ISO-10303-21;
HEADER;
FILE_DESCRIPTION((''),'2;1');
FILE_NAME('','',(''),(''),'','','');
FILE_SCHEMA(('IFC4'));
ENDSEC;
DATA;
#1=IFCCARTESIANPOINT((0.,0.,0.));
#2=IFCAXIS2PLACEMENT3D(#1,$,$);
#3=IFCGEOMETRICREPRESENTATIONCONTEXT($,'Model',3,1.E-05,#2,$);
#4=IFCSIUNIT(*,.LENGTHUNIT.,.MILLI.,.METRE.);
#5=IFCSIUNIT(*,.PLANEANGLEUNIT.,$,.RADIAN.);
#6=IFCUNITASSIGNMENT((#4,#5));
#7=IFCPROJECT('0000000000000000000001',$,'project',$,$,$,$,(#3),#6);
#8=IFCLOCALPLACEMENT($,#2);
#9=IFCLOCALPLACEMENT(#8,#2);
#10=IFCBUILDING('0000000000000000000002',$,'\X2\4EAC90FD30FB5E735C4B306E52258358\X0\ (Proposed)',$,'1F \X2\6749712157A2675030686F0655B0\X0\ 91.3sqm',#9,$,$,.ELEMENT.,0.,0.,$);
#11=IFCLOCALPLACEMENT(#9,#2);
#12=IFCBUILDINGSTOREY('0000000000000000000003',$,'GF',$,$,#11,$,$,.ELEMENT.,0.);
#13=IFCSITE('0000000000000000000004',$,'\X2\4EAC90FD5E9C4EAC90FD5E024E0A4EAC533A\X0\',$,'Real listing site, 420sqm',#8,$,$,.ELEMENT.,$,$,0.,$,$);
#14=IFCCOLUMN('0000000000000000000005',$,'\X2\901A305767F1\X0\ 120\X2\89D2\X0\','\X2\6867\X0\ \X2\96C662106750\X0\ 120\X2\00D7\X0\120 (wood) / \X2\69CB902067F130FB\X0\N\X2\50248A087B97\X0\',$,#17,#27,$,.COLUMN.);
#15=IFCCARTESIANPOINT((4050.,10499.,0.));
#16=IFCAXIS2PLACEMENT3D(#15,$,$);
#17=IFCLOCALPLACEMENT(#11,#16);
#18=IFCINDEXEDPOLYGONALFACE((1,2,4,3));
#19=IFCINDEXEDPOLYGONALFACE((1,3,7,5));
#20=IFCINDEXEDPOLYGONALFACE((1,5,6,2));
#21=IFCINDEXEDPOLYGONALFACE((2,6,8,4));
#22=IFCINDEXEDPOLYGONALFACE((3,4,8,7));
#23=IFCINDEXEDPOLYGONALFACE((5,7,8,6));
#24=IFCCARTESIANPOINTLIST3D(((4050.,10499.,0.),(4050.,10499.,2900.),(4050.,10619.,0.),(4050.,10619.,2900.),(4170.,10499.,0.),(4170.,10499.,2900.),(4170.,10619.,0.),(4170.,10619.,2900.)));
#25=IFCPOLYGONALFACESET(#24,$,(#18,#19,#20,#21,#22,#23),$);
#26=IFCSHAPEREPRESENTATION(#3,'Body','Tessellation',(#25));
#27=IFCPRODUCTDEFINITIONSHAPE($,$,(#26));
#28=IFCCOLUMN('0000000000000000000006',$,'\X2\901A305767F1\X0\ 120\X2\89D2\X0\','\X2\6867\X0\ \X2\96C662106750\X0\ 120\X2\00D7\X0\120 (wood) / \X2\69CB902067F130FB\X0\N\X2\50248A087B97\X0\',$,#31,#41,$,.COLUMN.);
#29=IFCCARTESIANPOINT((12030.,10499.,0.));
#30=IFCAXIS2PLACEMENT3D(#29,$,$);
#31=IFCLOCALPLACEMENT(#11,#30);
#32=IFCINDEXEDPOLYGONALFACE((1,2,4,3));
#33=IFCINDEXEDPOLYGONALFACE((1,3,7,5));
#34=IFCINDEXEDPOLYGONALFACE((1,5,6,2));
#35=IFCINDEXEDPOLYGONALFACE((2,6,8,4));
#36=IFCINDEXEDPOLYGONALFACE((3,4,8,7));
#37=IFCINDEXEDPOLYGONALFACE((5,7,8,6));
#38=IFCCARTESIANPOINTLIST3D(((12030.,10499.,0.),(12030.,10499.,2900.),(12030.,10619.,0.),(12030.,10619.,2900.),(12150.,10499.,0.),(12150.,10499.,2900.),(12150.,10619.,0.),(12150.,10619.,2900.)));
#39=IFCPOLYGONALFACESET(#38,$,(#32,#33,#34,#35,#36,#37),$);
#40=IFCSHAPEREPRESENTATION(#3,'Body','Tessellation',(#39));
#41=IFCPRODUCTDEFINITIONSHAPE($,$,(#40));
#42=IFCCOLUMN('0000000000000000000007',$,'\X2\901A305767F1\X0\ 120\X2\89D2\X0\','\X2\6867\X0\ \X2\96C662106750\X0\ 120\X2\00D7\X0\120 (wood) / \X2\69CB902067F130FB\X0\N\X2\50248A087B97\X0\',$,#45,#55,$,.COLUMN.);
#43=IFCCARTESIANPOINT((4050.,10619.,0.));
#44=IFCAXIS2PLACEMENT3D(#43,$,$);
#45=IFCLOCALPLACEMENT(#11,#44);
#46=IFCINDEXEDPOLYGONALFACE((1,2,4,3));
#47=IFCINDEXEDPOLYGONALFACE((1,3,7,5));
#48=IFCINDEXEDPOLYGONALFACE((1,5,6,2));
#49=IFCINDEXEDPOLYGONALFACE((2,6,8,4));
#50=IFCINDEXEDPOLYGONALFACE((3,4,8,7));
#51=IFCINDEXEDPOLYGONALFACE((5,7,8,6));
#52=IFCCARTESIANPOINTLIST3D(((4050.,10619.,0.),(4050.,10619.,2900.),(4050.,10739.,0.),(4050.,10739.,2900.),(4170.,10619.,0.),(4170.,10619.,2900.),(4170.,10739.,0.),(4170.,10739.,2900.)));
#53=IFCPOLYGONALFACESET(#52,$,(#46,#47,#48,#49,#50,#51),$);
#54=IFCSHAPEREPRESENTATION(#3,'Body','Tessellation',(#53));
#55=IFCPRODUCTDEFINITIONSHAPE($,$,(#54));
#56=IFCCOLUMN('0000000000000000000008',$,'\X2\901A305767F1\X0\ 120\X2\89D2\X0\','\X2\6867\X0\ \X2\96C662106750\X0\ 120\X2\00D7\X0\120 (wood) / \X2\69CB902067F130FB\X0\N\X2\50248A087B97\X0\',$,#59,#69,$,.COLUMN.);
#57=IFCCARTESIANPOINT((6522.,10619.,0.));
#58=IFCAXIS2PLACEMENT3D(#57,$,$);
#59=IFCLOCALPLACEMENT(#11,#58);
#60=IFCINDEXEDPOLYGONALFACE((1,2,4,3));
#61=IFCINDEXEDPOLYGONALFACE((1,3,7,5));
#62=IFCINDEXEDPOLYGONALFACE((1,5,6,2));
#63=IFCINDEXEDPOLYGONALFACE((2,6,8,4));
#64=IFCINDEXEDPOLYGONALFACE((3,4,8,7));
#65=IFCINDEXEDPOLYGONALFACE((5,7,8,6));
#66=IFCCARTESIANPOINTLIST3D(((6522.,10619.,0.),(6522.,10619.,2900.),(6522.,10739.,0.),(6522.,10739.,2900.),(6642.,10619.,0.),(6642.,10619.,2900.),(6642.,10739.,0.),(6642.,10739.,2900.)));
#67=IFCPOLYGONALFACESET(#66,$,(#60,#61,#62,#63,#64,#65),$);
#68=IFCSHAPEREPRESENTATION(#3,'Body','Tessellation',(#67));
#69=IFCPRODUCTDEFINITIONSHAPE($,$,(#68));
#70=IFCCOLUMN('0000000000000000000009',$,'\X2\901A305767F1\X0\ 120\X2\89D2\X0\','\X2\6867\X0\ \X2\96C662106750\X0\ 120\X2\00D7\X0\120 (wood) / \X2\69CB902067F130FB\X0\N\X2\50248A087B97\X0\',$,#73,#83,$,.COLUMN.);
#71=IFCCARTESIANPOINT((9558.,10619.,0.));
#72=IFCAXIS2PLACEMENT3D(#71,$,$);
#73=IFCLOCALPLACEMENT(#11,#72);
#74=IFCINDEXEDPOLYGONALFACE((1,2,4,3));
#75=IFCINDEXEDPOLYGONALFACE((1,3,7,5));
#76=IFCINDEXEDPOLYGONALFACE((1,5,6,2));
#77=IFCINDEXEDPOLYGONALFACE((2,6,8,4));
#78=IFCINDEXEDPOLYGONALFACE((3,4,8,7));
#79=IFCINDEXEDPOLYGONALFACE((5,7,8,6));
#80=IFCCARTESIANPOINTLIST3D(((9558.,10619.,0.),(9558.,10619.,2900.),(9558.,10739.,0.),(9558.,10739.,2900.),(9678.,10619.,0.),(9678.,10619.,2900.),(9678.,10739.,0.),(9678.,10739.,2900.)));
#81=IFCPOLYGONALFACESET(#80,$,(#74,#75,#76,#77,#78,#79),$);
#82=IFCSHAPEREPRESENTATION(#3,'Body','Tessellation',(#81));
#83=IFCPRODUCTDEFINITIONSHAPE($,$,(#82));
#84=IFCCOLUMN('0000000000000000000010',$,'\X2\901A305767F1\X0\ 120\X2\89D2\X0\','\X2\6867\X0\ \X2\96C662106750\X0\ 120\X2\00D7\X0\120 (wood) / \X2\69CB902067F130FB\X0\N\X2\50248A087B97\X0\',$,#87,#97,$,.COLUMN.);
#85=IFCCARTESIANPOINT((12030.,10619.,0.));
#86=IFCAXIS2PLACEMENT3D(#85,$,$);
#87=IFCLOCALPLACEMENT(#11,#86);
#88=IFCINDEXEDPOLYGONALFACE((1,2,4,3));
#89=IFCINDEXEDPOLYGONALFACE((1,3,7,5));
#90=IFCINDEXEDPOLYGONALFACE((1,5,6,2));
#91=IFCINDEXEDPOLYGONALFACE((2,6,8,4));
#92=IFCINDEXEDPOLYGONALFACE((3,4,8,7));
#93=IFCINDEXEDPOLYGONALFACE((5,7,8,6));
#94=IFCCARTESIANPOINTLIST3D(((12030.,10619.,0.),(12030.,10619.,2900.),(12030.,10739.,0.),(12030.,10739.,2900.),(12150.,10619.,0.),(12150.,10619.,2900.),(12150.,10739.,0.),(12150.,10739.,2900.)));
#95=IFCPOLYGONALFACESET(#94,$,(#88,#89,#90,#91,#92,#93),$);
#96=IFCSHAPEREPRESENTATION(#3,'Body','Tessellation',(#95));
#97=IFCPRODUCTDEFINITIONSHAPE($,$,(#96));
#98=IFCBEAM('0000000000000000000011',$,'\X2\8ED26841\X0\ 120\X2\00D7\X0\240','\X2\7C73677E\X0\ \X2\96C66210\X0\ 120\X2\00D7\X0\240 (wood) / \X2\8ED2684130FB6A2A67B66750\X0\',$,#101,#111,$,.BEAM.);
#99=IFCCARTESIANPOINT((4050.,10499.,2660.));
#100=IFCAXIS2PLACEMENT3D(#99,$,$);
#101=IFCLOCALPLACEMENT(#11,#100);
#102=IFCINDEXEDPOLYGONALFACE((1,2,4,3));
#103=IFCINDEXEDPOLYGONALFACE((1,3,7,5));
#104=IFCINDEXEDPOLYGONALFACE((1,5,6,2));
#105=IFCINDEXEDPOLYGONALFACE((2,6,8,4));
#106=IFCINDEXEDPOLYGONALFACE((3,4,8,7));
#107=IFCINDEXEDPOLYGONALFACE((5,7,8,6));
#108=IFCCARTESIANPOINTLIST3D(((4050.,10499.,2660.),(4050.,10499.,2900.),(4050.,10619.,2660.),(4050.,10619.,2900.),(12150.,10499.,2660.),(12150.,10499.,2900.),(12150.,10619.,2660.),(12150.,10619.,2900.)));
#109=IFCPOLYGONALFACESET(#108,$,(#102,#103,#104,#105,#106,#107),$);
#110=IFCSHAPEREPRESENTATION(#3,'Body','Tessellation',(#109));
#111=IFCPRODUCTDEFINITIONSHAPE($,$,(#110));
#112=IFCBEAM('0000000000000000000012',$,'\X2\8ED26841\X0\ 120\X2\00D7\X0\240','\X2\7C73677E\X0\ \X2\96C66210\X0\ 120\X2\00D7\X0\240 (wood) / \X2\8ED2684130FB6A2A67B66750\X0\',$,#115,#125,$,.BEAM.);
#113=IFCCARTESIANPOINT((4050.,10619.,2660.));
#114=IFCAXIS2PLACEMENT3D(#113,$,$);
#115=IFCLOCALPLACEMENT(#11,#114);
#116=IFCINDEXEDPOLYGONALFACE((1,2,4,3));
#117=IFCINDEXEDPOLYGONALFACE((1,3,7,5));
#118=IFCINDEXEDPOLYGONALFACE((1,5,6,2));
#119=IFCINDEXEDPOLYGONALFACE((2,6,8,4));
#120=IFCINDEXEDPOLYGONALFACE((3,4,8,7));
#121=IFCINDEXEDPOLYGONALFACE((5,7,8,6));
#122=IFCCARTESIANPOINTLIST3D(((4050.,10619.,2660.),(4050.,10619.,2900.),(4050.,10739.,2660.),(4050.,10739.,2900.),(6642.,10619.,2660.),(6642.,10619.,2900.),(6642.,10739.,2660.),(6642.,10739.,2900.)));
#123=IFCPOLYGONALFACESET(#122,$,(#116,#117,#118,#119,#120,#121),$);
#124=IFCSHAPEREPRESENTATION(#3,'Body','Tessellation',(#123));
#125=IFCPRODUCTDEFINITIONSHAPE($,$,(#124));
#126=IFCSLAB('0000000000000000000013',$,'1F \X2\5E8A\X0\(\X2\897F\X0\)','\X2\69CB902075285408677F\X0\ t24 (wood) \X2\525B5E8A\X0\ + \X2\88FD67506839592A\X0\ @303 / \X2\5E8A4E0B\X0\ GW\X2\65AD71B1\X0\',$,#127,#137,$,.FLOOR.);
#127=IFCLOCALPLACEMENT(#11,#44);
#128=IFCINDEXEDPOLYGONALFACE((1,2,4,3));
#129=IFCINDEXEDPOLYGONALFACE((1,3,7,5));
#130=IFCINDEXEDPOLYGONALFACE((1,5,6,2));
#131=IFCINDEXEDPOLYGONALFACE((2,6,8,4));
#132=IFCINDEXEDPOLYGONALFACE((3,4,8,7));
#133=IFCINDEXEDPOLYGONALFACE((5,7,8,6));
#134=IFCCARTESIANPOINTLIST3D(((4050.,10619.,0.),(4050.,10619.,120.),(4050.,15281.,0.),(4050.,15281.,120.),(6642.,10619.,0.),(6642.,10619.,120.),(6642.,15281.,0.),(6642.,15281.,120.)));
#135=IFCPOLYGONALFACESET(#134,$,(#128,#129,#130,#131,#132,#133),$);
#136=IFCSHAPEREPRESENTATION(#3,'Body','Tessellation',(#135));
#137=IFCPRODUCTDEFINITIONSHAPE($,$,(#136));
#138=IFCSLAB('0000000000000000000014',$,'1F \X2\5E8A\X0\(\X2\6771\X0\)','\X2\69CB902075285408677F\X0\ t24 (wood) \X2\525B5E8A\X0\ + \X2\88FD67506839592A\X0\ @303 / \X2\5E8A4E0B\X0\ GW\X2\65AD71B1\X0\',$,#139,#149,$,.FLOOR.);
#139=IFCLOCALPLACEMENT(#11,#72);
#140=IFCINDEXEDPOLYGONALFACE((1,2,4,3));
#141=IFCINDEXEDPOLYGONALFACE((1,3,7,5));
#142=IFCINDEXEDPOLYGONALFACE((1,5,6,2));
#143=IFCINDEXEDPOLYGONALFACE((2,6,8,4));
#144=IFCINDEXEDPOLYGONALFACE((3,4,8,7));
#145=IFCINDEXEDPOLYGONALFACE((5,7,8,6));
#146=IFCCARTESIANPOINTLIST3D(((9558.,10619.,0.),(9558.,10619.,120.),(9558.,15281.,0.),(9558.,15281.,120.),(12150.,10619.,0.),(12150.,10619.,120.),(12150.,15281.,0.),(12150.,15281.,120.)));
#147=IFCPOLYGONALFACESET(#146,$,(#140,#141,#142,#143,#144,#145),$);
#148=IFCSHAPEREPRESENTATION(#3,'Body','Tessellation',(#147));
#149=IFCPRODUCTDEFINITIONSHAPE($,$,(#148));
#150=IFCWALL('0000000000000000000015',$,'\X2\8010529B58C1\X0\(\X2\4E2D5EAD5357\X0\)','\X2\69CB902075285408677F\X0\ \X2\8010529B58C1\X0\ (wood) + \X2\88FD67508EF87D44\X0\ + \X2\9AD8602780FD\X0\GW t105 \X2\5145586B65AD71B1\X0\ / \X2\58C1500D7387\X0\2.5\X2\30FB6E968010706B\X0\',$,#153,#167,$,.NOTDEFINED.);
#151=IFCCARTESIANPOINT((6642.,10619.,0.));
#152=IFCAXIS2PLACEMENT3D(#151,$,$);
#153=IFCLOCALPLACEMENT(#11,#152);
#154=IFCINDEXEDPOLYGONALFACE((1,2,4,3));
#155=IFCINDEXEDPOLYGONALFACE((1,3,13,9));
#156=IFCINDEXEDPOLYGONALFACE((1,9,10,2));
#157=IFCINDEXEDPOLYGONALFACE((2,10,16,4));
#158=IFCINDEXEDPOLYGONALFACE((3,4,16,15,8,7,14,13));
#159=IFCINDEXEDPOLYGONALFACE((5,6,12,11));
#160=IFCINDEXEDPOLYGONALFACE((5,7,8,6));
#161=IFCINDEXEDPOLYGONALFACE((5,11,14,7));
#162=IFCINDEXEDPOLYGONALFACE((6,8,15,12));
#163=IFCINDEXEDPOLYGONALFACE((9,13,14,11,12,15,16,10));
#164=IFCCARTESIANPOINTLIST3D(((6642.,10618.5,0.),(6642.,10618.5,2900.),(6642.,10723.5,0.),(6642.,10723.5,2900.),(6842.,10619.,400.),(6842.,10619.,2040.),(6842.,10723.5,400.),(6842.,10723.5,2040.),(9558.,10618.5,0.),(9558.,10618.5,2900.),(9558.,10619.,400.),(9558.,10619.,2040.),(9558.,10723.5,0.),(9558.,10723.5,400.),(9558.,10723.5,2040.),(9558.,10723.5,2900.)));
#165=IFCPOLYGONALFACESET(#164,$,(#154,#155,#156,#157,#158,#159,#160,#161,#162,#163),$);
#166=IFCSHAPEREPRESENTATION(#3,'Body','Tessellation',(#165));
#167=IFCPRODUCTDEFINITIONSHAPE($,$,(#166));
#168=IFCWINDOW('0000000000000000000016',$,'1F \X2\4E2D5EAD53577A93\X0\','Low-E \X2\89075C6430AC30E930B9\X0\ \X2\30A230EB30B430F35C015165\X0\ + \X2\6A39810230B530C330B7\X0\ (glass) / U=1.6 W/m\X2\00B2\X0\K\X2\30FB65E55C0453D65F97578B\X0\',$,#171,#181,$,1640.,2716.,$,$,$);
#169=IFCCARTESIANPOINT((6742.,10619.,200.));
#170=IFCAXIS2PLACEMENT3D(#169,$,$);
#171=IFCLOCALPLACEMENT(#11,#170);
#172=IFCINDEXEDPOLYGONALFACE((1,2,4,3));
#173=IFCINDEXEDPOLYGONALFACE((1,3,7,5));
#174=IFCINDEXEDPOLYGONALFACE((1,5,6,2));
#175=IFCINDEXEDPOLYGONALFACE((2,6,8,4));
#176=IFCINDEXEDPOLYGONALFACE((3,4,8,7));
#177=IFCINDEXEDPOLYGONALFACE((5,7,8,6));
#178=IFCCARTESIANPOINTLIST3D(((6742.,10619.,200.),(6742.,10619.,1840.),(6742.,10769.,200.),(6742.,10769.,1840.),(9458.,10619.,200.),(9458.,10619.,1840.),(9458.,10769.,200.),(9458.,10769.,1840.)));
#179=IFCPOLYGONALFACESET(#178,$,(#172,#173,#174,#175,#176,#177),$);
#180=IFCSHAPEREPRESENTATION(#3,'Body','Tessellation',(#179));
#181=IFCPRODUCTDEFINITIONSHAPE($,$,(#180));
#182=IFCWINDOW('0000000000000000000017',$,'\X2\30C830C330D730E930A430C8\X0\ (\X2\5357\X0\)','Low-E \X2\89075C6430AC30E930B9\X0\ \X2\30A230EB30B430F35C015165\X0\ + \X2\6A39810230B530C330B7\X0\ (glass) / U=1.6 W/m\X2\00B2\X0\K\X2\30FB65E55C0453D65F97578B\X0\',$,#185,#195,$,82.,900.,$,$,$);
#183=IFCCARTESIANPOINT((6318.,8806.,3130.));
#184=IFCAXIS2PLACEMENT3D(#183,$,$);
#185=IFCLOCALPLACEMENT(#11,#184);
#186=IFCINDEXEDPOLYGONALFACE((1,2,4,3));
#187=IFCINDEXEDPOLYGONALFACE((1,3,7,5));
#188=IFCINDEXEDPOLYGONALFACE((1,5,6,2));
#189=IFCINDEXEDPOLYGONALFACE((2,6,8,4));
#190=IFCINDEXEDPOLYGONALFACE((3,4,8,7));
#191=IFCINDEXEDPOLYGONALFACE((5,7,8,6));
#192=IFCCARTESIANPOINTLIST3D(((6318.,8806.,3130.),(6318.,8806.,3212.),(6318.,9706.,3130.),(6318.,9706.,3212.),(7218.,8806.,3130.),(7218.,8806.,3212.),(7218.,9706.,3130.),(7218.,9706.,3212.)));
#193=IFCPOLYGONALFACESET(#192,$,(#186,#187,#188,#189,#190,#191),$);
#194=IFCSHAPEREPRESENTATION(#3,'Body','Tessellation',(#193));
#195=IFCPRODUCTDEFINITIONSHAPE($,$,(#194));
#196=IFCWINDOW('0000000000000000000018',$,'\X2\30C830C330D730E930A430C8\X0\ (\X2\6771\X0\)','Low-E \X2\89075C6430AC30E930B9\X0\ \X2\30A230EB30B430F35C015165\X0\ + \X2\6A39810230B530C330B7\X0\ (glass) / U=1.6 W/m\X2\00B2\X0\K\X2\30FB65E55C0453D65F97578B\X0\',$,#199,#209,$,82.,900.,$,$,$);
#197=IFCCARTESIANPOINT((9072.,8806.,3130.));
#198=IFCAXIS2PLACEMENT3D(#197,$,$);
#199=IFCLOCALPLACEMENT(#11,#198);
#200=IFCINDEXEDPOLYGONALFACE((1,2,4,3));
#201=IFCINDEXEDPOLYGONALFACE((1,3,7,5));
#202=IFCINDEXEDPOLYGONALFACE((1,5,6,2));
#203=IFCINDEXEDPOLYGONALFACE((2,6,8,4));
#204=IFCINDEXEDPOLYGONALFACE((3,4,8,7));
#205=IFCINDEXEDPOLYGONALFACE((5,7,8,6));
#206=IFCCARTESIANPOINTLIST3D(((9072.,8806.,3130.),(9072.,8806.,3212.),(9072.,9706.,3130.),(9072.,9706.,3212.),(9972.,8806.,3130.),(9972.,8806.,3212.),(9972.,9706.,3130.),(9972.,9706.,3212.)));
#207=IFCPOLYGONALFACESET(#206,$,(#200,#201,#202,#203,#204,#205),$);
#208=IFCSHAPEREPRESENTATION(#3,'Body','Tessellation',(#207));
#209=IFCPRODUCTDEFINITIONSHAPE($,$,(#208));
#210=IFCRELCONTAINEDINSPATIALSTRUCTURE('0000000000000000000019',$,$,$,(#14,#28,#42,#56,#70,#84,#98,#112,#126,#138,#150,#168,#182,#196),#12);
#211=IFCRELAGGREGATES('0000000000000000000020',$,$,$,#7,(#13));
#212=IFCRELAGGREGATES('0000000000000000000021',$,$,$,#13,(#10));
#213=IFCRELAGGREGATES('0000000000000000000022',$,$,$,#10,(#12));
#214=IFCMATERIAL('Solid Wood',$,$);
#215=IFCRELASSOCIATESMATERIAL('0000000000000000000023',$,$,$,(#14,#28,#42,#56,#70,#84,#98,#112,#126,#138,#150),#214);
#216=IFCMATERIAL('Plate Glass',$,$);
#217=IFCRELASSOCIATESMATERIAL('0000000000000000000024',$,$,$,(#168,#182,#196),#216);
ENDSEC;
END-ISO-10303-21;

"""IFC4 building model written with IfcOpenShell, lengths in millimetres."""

from ifc_helpers import new_model, si_unit, frame, frame_2d, origin, place, context, project, spatial, rectangle, extrude, material, element, fill, save


model = new_model("IFC4")

# Units and contexts
model_context = context("Model", 3, precision=1e-05, world=origin())
ifc_project = project(units=[si_unit("LENGTHUNIT", "METRE", prefix="MILLI"), si_unit("PLANEANGLEUNIT", "RADIAN")], contexts=[model_context])

# Site, building, storey
site_placement = place(None, origin())
site = spatial("IfcSite", under=ifc_project, at=site_placement, Name="京都府京都市上京区", ObjectType="Real listing site, 420sqm", CompositionType="ELEMENT", RefElevation=0.0)
building_placement = place(site_placement, origin())
building = spatial("IfcBuilding", under=site, at=building_placement, Name="京都・平屋の別荘 (Proposed)", ObjectType="1F 杉無垢材と漆喰 91.3sqm", CompositionType="ELEMENT", ElevationOfRefHeight=0.0, ElevationOfTerrain=0.0)
storey_placement = place(building_placement, origin())
storey = spatial("IfcBuildingStorey", under=building, at=storey_placement, Name="GF", CompositionType="ELEMENT", Elevation=0.0)

# Columns
ifc_material_1 = material(Name="Solid Wood")
column_1_placement = place(storey_placement, frame((4050.0, 10499.0, 0.0)))
element("IfcColumn", 1, at=column_1_placement, inside=storey, material=ifc_material_1, Name="通し柱 120角", Description="桧 集成材 120×120 (wood) / 構造柱・N値計算", PredefinedType="COLUMN", context=model_context, shape_type="SweptSolid", body=[
    extrude(rectangle(XDim=120.0, YDim=120.0, at=frame_2d((60.0, 60.0))), frame((4050.0, 10499.0, 0.0)), (0.0, 0.0, 1.0), 2900.0),
])
column_2_placement = place(storey_placement, frame((12030.0, 10499.0, 0.0)))
element("IfcColumn", 2, at=column_2_placement, inside=storey, material=ifc_material_1, Name="通し柱 120角", Description="桧 集成材 120×120 (wood) / 構造柱・N値計算", PredefinedType="COLUMN", context=model_context, shape_type="SweptSolid", body=[
    extrude(rectangle(XDim=120.0, YDim=120.0, at=frame_2d((60.0, 60.0))), frame((12030.0, 10499.0, 0.0)), (0.0, 0.0, 1.0), 2900.0),
])
column_3_placement = place(storey_placement, frame((4050.0, 10619.0, 0.0)))
element("IfcColumn", 3, at=column_3_placement, inside=storey, material=ifc_material_1, Name="通し柱 120角", Description="桧 集成材 120×120 (wood) / 構造柱・N値計算", PredefinedType="COLUMN", context=model_context, shape_type="SweptSolid", body=[
    extrude(rectangle(XDim=120.0, YDim=120.0, at=frame_2d((60.0, 60.0))), frame((4050.0, 10619.0, 0.0)), (0.0, 0.0, 1.0), 2900.0),
])
column_4_placement = place(storey_placement, frame((6522.0, 10619.0, 0.0)))
element("IfcColumn", 4, at=column_4_placement, inside=storey, material=ifc_material_1, Name="通し柱 120角", Description="桧 集成材 120×120 (wood) / 構造柱・N値計算", PredefinedType="COLUMN", context=model_context, shape_type="SweptSolid", body=[
    extrude(rectangle(XDim=120.0, YDim=120.0, at=frame_2d((60.0, 60.0))), frame((6522.0, 10619.0, 0.0)), (0.0, 0.0, 1.0), 2900.0),
])
column_5_placement = place(storey_placement, frame((9558.0, 10619.0, 0.0)))
element("IfcColumn", 5, at=column_5_placement, inside=storey, material=ifc_material_1, Name="通し柱 120角", Description="桧 集成材 120×120 (wood) / 構造柱・N値計算", PredefinedType="COLUMN", context=model_context, shape_type="SweptSolid", body=[
    extrude(rectangle(XDim=120.0, YDim=120.0, at=frame_2d((60.0, 60.0))), frame((9558.0, 10619.0, 0.0)), (0.0, 0.0, 1.0), 2900.0),
])
column_6_placement = place(storey_placement, frame((12030.0, 10619.0, 0.0)))
element("IfcColumn", 6, at=column_6_placement, inside=storey, material=ifc_material_1, Name="通し柱 120角", Description="桧 集成材 120×120 (wood) / 構造柱・N値計算", PredefinedType="COLUMN", context=model_context, shape_type="SweptSolid", body=[
    extrude(rectangle(XDim=120.0, YDim=120.0, at=frame_2d((60.0, 60.0))), frame((12030.0, 10619.0, 0.0)), (0.0, 0.0, 1.0), 2900.0),
])

# Beams
beam_1_placement = place(storey_placement, frame((4050.0, 10499.0, 2660.0)))
element("IfcBeam", 7, at=beam_1_placement, inside=storey, material=ifc_material_1, Name="軒桁 120×240", Description="米松 集成 120×240 (wood) / 軒桁・横架材", PredefinedType="BEAM", context=model_context, shape_type="SweptSolid", body=[
    extrude(rectangle(XDim=8100.0, YDim=120.0, at=frame_2d((4050.0, 60.0))), frame((4050.0, 10499.0, 2660.0)), (0.0, 0.0, 1.0), 240.0),
])
beam_2_placement = place(storey_placement, frame((4050.0, 10619.0, 2660.0)))
element("IfcBeam", 8, at=beam_2_placement, inside=storey, material=ifc_material_1, Name="軒桁 120×240", Description="米松 集成 120×240 (wood) / 軒桁・横架材", PredefinedType="BEAM", context=model_context, shape_type="SweptSolid", body=[
    extrude(rectangle(XDim=2592.0, YDim=120.0, at=frame_2d((1296.0, 60.0))), frame((4050.0, 10619.0, 2660.0)), (0.0, 0.0, 1.0), 240.0),
])

# Slabs
slab_1_placement = place(storey_placement, frame((4050.0, 10619.0, 0.0)))
element("IfcSlab", 9, at=slab_1_placement, inside=storey, material=ifc_material_1, Name="1F 床(西)", Description="構造用合板 t24 (wood) 剛床 + 製材根太 @303 / 床下 GW断熱", PredefinedType="FLOOR", context=model_context, shape_type="SweptSolid", body=[
    extrude(rectangle(XDim=2592.0, YDim=4662.0, at=frame_2d((1296.0, 2331.0))), frame((4050.0, 10619.0, 0.0)), (0.0, 0.0, 1.0), 120.0),
])
slab_2_placement = place(storey_placement, frame((9558.0, 10619.0, 0.0)))
element("IfcSlab", 10, at=slab_2_placement, inside=storey, material=ifc_material_1, Name="1F 床(東)", Description="構造用合板 t24 (wood) 剛床 + 製材根太 @303 / 床下 GW断熱", PredefinedType="FLOOR", context=model_context, shape_type="SweptSolid", body=[
    extrude(rectangle(XDim=2592.0, YDim=4662.0, at=frame_2d((1296.0, 2331.0))), frame((9558.0, 10619.0, 0.0)), (0.0, 0.0, 1.0), 120.0),
])

# Wall, opening, window
wall_1_placement = place(storey_placement, frame((6642.0, 10619.0, 0.0)))
wall_1 = element("IfcWall", 11, at=wall_1_placement, inside=storey, material=ifc_material_1, Name="耐力壁(中庭南)", Description="構造用合板 耐力壁 (wood) + 製材軸組 + 高性能GW t105 充填断熱 / 壁倍率2.5・準耐火", PredefinedType="NOTDEFINED", context=model_context, shape_type="SweptSolid", body=[
    extrude(rectangle(XDim=2916.0, YDim=105.0, at=frame_2d((1458.0, 52.0))), frame((6642.0, 10619.0, 0.0)), (0.0, 0.0, 1.0), 2900.0),
])
opening_placement = place(storey_placement, frame((6742.0, 10619.0, 200.0)))
opening = element("IfcOpeningElement", 12, at=opening_placement, cuts=wall_1, PredefinedType="NOTDEFINED", context=model_context, shape_type="SweptSolid", body=[
    extrude(rectangle(XDim=2716.0, YDim=150.0, at=frame_2d((1358.0, 75.0))), frame((6742.0, 10619.0, 200.0)), (0.0, 0.0, 1.0), 1640.0),
])
ifc_material_2 = material(Name="Plate Glass")
window_1_placement = place(storey_placement, frame((6742.0, 10619.0, 200.0)))
window_1 = element("IfcWindow", 13, at=window_1_placement, inside=storey, material=ifc_material_2, Name="1F 中庭南窓", Description="Low-E 複層ガラス アルゴン封入 + 樹脂サッシ (glass) / U=1.6 W/m²K・日射取得型", OverallHeight=1640.0, OverallWidth=2716.0, context=model_context, shape_type="SweptSolid", body=[
    extrude(rectangle(XDim=2716.0, YDim=150.0, at=frame_2d((1358.0, 75.0))), frame((6742.0, 10619.0, 200.0)), (0.0, 0.0, 1.0), 1640.0),
])
fill(opening, window_1)

# Windows
window_2_placement = place(storey_placement, frame((6318.0, 8806.0, 3130.0)))
element("IfcWindow", 14, at=window_2_placement, inside=storey, material=ifc_material_2, Name="トップライト (南)", Description="Low-E 複層ガラス アルゴン封入 + 樹脂サッシ (glass) / U=1.6 W/m²K・日射取得型", OverallHeight=82.0, OverallWidth=900.0, context=model_context, shape_type="SweptSolid", body=[
    extrude(rectangle(XDim=900.0, YDim=900.0, at=frame_2d((450.0, 450.0))), frame((6318.0, 8806.0, 3130.0)), (0.0, 0.0, 1.0), 82.0),
])
window_3_placement = place(storey_placement, frame((9072.0, 8806.0, 3130.0)))
element("IfcWindow", 15, at=window_3_placement, inside=storey, material=ifc_material_2, Name="トップライト (東)", Description="Low-E 複層ガラス アルゴン封入 + 樹脂サッシ (glass) / U=1.6 W/m²K・日射取得型", OverallHeight=82.0, OverallWidth=900.0, context=model_context, shape_type="SweptSolid", body=[
    extrude(rectangle(XDim=900.0, YDim=900.0, at=frame_2d((450.0, 450.0))), frame((9072.0, 8806.0, 3130.0)), (0.0, 0.0, 1.0), 82.0),
])

save(model, "model.ifc")
